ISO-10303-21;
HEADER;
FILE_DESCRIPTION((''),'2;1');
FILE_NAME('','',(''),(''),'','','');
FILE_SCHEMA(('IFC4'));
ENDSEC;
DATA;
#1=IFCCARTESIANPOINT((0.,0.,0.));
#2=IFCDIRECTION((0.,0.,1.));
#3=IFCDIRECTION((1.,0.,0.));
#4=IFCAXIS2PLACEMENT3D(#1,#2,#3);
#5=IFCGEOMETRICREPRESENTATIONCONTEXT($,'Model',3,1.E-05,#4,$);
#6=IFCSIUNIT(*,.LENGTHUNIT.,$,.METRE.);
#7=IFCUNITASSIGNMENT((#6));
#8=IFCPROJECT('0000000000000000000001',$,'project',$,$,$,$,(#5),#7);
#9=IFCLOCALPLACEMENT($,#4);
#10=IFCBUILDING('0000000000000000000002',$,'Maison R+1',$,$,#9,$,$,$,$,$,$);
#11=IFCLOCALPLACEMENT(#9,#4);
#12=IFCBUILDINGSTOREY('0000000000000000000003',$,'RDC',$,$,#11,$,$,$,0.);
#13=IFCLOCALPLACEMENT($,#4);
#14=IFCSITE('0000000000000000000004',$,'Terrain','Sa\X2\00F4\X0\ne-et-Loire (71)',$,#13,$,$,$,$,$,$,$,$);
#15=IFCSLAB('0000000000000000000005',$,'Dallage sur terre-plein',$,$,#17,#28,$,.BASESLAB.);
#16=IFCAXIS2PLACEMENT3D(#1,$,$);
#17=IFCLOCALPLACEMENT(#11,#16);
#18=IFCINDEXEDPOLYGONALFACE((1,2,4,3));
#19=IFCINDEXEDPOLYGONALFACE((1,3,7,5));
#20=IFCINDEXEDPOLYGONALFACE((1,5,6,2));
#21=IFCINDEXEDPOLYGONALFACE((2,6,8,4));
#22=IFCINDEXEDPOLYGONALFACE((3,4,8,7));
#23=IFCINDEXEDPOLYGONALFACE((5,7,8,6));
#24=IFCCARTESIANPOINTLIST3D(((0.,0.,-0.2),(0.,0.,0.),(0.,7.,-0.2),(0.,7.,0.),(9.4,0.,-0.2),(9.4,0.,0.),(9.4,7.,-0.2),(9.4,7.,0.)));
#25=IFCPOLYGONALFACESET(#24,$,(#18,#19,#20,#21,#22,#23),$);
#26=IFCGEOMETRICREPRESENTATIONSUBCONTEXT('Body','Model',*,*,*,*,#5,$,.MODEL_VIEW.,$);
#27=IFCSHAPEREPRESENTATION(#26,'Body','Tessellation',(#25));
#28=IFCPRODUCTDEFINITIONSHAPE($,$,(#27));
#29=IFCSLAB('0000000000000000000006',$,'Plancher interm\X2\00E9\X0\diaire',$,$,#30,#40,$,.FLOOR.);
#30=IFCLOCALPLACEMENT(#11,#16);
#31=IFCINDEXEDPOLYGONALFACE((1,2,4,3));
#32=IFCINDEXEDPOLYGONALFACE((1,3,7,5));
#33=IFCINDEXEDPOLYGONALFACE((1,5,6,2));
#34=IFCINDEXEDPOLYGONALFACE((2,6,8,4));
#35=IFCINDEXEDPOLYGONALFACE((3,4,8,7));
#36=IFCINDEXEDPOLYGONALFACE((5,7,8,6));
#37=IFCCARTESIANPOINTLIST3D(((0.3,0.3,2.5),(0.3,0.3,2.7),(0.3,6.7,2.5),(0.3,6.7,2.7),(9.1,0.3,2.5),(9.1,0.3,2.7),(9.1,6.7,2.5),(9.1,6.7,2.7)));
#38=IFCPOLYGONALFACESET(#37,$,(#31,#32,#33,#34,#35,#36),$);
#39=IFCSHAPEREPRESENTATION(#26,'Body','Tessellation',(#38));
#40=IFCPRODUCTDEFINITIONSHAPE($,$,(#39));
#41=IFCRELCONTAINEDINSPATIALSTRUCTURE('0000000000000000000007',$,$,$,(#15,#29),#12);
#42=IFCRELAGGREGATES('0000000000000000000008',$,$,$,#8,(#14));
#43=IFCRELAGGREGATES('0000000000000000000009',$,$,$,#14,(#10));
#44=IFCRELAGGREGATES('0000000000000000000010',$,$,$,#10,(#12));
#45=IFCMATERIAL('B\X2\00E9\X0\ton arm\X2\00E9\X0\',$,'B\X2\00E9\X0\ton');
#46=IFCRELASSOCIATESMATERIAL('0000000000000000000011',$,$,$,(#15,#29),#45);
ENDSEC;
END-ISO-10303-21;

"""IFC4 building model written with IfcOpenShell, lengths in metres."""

from ifc_helpers import new_model, si_unit, frame, frame_2d, origin_with_axes, place, context, subcontext, project, spatial, rectangle, extrude, material, element, save


model = new_model("IFC4")

# Units and contexts
model_context = context("Model", 3, precision=1e-05, world=origin_with_axes())
body_context = subcontext(model_context, "Body", "Model", "MODEL_VIEW")
ifc_project = project(units=[si_unit("LENGTHUNIT", "METRE")], contexts=[model_context])

# Site, building, storey
site_placement = place(None, origin_with_axes())
site = spatial("IfcSite", under=ifc_project, at=site_placement, Name="Terrain", Description="Saône-et-Loire (71)")
building_placement = place(None, origin_with_axes())
building = spatial("IfcBuilding", under=site, at=building_placement, Name="Maison R+1")
storey_placement = place(building_placement, origin_with_axes())
storey = spatial("IfcBuildingStorey", under=building, at=storey_placement, Name="RDC", Elevation=0.0)

# Slabs
ifc_material_1 = material(Name="Béton armé", Category="Béton")
slab_1_placement = place(storey_placement, frame((0.0, 0.0, -0.2), z_axis=(0.0, 0.0, 1.0), x_axis=(1.0, 0.0, 0.0)))
element("IfcSlab", 1, at=slab_1_placement, inside=storey, material=ifc_material_1, Name="Dallage sur terre-plein", PredefinedType="BASESLAB", context=body_context, shape_type="SweptSolid", body=[
    extrude(rectangle(XDim=9.4, YDim=7.0, at=frame_2d((4.7, 3.5))), origin_with_axes(), (0.0, 0.0, 1.0), 0.2),
])
slab_2_placement = place(storey_placement, frame((0.3, 0.3, 2.5), z_axis=(0.0, 0.0, 1.0), x_axis=(1.0, 0.0, 0.0)))
element("IfcSlab", 2, at=slab_2_placement, inside=storey, material=ifc_material_1, Name="Plancher intermédiaire", PredefinedType="FLOOR", context=body_context, shape_type="SweptSolid", body=[
    extrude(rectangle(XDim=8.8, YDim=6.4, at=frame_2d((4.4, 3.2))), origin_with_axes(), (0.0, 0.0, 1.0), 0.2),
])

save(model, "model.ifc")
